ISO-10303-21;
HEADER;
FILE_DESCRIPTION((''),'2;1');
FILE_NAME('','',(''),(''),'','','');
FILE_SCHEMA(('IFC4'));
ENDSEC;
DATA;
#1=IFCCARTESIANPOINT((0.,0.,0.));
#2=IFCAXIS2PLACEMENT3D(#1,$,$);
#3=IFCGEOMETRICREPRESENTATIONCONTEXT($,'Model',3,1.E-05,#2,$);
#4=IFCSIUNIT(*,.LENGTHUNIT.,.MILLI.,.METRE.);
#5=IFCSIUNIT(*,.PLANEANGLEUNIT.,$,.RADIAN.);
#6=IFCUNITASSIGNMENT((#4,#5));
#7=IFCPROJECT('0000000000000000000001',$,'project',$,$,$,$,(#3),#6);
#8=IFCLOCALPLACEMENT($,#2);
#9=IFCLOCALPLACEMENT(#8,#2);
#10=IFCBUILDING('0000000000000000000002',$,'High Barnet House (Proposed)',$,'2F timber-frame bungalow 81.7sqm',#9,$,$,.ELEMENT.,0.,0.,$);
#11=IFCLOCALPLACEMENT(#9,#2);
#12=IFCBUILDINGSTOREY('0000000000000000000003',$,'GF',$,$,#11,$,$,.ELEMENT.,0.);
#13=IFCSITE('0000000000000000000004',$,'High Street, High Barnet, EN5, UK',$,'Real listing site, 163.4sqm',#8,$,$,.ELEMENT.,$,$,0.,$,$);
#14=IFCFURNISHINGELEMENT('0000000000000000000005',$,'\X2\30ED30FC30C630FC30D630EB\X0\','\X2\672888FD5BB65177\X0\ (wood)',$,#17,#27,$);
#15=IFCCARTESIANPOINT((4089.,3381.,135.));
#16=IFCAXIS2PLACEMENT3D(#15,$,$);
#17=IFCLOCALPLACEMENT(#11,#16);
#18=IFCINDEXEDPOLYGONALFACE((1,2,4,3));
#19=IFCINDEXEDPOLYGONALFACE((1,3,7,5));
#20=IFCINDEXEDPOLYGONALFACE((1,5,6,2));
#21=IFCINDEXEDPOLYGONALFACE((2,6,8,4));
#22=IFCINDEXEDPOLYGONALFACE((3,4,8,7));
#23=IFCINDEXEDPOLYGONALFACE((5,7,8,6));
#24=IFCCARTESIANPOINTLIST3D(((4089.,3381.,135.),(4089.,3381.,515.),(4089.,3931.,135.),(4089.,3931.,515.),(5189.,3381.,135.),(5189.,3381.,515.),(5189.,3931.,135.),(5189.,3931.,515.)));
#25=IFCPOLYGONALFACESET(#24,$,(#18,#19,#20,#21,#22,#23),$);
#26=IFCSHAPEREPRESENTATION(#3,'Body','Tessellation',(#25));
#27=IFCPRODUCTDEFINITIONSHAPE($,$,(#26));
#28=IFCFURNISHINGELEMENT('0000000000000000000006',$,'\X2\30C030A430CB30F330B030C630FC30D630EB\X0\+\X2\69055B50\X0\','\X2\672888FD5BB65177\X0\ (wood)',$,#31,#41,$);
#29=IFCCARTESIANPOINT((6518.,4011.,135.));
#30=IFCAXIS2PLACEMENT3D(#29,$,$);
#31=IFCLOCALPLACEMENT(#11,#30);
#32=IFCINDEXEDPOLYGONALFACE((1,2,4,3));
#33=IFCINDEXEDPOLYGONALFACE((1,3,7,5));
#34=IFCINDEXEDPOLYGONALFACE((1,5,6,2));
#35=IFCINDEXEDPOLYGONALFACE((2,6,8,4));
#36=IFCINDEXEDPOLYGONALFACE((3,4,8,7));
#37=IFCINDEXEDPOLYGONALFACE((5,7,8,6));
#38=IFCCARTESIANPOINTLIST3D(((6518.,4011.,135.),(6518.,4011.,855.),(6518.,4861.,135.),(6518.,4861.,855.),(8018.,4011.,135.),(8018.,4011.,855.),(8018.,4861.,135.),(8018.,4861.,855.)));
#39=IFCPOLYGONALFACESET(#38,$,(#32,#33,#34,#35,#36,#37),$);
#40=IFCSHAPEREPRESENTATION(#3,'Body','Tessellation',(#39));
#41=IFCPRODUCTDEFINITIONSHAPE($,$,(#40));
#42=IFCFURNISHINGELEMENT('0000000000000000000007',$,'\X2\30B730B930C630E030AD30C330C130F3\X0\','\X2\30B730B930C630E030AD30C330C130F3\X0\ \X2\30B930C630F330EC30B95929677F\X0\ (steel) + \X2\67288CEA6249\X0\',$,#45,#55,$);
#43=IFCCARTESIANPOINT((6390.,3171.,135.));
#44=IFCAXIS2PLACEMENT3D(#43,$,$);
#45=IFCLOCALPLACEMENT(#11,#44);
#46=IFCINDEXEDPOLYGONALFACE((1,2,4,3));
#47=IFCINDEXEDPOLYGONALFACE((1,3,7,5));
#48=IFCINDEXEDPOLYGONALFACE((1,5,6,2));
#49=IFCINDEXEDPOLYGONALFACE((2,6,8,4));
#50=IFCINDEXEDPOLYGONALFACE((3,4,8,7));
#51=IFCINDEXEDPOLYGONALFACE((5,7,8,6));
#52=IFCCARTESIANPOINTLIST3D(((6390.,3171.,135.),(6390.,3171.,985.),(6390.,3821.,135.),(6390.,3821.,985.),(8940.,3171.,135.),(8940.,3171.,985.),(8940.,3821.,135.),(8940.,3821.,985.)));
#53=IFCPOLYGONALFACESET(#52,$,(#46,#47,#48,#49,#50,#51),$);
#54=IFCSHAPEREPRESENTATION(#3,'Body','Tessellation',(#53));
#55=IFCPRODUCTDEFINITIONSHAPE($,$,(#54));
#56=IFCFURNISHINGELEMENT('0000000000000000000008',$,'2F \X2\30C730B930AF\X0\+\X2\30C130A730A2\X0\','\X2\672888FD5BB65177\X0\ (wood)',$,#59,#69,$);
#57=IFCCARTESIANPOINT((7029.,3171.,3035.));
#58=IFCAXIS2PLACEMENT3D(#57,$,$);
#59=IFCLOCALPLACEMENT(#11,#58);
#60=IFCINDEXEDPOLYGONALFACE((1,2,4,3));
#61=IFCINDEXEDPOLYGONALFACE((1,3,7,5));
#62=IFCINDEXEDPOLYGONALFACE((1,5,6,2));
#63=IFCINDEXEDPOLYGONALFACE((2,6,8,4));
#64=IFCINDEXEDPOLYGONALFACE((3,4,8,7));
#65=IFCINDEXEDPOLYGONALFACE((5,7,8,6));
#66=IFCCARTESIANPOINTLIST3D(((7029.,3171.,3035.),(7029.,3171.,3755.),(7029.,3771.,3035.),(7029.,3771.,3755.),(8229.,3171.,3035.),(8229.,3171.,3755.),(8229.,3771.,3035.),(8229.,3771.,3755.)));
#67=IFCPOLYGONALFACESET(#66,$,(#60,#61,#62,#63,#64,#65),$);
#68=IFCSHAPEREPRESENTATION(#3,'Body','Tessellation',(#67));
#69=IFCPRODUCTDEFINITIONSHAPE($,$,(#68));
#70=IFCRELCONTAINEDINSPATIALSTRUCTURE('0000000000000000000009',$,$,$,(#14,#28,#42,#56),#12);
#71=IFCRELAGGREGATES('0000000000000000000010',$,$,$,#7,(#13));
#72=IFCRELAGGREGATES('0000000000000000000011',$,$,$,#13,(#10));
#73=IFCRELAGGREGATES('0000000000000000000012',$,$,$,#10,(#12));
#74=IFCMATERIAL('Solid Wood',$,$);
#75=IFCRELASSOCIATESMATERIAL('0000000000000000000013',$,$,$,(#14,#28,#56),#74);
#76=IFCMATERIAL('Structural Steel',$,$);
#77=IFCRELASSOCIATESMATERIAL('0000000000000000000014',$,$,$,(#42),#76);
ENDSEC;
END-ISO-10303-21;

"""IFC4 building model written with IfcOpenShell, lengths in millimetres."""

from ifc_helpers import new_model, si_unit, frame, frame_2d, origin, place, context, project, spatial, rectangle, extrude, material, element, save


model = new_model("IFC4")

# Units and contexts
model_context = context("Model", 3, precision=1e-05, world=origin())
ifc_project = project(units=[si_unit("LENGTHUNIT", "METRE", prefix="MILLI"), si_unit("PLANEANGLEUNIT", "RADIAN")], contexts=[model_context])

# Site, building, storey
site_placement = place(None, origin())
site = spatial("IfcSite", under=ifc_project, at=site_placement, Name="High Street, High Barnet, EN5, UK", ObjectType="Real listing site, 163.4sqm", CompositionType="ELEMENT", RefElevation=0.0)
building_placement = place(site_placement, origin())
building = spatial("IfcBuilding", under=site, at=building_placement, Name="High Barnet House (Proposed)", ObjectType="2F timber-frame bungalow 81.7sqm", CompositionType="ELEMENT", ElevationOfRefHeight=0.0, ElevationOfTerrain=0.0)
storey_placement = place(building_placement, origin())
storey = spatial("IfcBuildingStorey", under=building, at=storey_placement, Name="GF", CompositionType="ELEMENT", Elevation=0.0)

# Shared definitions
ifc_material_1 = material(Name="Solid Wood")

# Shared definitions
ifc_material_2 = material(Name="Structural Steel")

# Furnishing elements
furnishing_1_placement = place(storey_placement, frame((4089.0, 3381.0, 135.0)))
element("IfcFurnishingElement", 1, at=furnishing_1_placement, inside=storey, material=ifc_material_1, Name="ローテーブル", Description="木製家具 (wood)", context=model_context, shape_type="SweptSolid", body=[
    extrude(rectangle(XDim=1100.0, YDim=550.0, at=frame_2d((550.0, 275.0))), frame((4089.0, 3381.0, 135.0)), (0.0, 0.0, 1.0), 380.0),
])
furnishing_2_placement = place(storey_placement, frame((6518.0, 4011.0, 135.0)))
element("IfcFurnishingElement", 2, at=furnishing_2_placement, inside=storey, material=ifc_material_1, Name="ダイニングテーブル+椅子", Description="木製家具 (wood)", context=model_context, shape_type="SweptSolid", body=[
    extrude(rectangle(XDim=1500.0, YDim=850.0, at=frame_2d((750.0, 425.0))), frame((6518.0, 4011.0, 135.0)), (0.0, 0.0, 1.0), 720.0),
])
furnishing_3_placement = place(storey_placement, frame((6390.0, 3171.0, 135.0)))
element("IfcFurnishingElement", 3, at=furnishing_3_placement, inside=storey, material=ifc_material_2, Name="システムキッチン", Description="システムキッチン ステンレス天板 (steel) + 木質扉", context=model_context, shape_type="SweptSolid", body=[
    extrude(rectangle(XDim=2550.0, YDim=650.0, at=frame_2d((1275.0, 325.0))), frame((6390.0, 3171.0, 135.0)), (0.0, 0.0, 1.0), 850.0),
])
furnishing_4_placement = place(storey_placement, frame((7029.0, 3171.0, 3035.0)))
element("IfcFurnishingElement", 4, at=furnishing_4_placement, inside=storey, material=ifc_material_1, Name="2F デスク+チェア", Description="木製家具 (wood)", context=model_context, shape_type="SweptSolid", body=[
    extrude(rectangle(XDim=1200.0, YDim=600.0, at=frame_2d((600.0, 300.0))), frame((7029.0, 3171.0, 3035.0)), (0.0, 0.0, 1.0), 720.0),
])

save(model, "model.ifc")
